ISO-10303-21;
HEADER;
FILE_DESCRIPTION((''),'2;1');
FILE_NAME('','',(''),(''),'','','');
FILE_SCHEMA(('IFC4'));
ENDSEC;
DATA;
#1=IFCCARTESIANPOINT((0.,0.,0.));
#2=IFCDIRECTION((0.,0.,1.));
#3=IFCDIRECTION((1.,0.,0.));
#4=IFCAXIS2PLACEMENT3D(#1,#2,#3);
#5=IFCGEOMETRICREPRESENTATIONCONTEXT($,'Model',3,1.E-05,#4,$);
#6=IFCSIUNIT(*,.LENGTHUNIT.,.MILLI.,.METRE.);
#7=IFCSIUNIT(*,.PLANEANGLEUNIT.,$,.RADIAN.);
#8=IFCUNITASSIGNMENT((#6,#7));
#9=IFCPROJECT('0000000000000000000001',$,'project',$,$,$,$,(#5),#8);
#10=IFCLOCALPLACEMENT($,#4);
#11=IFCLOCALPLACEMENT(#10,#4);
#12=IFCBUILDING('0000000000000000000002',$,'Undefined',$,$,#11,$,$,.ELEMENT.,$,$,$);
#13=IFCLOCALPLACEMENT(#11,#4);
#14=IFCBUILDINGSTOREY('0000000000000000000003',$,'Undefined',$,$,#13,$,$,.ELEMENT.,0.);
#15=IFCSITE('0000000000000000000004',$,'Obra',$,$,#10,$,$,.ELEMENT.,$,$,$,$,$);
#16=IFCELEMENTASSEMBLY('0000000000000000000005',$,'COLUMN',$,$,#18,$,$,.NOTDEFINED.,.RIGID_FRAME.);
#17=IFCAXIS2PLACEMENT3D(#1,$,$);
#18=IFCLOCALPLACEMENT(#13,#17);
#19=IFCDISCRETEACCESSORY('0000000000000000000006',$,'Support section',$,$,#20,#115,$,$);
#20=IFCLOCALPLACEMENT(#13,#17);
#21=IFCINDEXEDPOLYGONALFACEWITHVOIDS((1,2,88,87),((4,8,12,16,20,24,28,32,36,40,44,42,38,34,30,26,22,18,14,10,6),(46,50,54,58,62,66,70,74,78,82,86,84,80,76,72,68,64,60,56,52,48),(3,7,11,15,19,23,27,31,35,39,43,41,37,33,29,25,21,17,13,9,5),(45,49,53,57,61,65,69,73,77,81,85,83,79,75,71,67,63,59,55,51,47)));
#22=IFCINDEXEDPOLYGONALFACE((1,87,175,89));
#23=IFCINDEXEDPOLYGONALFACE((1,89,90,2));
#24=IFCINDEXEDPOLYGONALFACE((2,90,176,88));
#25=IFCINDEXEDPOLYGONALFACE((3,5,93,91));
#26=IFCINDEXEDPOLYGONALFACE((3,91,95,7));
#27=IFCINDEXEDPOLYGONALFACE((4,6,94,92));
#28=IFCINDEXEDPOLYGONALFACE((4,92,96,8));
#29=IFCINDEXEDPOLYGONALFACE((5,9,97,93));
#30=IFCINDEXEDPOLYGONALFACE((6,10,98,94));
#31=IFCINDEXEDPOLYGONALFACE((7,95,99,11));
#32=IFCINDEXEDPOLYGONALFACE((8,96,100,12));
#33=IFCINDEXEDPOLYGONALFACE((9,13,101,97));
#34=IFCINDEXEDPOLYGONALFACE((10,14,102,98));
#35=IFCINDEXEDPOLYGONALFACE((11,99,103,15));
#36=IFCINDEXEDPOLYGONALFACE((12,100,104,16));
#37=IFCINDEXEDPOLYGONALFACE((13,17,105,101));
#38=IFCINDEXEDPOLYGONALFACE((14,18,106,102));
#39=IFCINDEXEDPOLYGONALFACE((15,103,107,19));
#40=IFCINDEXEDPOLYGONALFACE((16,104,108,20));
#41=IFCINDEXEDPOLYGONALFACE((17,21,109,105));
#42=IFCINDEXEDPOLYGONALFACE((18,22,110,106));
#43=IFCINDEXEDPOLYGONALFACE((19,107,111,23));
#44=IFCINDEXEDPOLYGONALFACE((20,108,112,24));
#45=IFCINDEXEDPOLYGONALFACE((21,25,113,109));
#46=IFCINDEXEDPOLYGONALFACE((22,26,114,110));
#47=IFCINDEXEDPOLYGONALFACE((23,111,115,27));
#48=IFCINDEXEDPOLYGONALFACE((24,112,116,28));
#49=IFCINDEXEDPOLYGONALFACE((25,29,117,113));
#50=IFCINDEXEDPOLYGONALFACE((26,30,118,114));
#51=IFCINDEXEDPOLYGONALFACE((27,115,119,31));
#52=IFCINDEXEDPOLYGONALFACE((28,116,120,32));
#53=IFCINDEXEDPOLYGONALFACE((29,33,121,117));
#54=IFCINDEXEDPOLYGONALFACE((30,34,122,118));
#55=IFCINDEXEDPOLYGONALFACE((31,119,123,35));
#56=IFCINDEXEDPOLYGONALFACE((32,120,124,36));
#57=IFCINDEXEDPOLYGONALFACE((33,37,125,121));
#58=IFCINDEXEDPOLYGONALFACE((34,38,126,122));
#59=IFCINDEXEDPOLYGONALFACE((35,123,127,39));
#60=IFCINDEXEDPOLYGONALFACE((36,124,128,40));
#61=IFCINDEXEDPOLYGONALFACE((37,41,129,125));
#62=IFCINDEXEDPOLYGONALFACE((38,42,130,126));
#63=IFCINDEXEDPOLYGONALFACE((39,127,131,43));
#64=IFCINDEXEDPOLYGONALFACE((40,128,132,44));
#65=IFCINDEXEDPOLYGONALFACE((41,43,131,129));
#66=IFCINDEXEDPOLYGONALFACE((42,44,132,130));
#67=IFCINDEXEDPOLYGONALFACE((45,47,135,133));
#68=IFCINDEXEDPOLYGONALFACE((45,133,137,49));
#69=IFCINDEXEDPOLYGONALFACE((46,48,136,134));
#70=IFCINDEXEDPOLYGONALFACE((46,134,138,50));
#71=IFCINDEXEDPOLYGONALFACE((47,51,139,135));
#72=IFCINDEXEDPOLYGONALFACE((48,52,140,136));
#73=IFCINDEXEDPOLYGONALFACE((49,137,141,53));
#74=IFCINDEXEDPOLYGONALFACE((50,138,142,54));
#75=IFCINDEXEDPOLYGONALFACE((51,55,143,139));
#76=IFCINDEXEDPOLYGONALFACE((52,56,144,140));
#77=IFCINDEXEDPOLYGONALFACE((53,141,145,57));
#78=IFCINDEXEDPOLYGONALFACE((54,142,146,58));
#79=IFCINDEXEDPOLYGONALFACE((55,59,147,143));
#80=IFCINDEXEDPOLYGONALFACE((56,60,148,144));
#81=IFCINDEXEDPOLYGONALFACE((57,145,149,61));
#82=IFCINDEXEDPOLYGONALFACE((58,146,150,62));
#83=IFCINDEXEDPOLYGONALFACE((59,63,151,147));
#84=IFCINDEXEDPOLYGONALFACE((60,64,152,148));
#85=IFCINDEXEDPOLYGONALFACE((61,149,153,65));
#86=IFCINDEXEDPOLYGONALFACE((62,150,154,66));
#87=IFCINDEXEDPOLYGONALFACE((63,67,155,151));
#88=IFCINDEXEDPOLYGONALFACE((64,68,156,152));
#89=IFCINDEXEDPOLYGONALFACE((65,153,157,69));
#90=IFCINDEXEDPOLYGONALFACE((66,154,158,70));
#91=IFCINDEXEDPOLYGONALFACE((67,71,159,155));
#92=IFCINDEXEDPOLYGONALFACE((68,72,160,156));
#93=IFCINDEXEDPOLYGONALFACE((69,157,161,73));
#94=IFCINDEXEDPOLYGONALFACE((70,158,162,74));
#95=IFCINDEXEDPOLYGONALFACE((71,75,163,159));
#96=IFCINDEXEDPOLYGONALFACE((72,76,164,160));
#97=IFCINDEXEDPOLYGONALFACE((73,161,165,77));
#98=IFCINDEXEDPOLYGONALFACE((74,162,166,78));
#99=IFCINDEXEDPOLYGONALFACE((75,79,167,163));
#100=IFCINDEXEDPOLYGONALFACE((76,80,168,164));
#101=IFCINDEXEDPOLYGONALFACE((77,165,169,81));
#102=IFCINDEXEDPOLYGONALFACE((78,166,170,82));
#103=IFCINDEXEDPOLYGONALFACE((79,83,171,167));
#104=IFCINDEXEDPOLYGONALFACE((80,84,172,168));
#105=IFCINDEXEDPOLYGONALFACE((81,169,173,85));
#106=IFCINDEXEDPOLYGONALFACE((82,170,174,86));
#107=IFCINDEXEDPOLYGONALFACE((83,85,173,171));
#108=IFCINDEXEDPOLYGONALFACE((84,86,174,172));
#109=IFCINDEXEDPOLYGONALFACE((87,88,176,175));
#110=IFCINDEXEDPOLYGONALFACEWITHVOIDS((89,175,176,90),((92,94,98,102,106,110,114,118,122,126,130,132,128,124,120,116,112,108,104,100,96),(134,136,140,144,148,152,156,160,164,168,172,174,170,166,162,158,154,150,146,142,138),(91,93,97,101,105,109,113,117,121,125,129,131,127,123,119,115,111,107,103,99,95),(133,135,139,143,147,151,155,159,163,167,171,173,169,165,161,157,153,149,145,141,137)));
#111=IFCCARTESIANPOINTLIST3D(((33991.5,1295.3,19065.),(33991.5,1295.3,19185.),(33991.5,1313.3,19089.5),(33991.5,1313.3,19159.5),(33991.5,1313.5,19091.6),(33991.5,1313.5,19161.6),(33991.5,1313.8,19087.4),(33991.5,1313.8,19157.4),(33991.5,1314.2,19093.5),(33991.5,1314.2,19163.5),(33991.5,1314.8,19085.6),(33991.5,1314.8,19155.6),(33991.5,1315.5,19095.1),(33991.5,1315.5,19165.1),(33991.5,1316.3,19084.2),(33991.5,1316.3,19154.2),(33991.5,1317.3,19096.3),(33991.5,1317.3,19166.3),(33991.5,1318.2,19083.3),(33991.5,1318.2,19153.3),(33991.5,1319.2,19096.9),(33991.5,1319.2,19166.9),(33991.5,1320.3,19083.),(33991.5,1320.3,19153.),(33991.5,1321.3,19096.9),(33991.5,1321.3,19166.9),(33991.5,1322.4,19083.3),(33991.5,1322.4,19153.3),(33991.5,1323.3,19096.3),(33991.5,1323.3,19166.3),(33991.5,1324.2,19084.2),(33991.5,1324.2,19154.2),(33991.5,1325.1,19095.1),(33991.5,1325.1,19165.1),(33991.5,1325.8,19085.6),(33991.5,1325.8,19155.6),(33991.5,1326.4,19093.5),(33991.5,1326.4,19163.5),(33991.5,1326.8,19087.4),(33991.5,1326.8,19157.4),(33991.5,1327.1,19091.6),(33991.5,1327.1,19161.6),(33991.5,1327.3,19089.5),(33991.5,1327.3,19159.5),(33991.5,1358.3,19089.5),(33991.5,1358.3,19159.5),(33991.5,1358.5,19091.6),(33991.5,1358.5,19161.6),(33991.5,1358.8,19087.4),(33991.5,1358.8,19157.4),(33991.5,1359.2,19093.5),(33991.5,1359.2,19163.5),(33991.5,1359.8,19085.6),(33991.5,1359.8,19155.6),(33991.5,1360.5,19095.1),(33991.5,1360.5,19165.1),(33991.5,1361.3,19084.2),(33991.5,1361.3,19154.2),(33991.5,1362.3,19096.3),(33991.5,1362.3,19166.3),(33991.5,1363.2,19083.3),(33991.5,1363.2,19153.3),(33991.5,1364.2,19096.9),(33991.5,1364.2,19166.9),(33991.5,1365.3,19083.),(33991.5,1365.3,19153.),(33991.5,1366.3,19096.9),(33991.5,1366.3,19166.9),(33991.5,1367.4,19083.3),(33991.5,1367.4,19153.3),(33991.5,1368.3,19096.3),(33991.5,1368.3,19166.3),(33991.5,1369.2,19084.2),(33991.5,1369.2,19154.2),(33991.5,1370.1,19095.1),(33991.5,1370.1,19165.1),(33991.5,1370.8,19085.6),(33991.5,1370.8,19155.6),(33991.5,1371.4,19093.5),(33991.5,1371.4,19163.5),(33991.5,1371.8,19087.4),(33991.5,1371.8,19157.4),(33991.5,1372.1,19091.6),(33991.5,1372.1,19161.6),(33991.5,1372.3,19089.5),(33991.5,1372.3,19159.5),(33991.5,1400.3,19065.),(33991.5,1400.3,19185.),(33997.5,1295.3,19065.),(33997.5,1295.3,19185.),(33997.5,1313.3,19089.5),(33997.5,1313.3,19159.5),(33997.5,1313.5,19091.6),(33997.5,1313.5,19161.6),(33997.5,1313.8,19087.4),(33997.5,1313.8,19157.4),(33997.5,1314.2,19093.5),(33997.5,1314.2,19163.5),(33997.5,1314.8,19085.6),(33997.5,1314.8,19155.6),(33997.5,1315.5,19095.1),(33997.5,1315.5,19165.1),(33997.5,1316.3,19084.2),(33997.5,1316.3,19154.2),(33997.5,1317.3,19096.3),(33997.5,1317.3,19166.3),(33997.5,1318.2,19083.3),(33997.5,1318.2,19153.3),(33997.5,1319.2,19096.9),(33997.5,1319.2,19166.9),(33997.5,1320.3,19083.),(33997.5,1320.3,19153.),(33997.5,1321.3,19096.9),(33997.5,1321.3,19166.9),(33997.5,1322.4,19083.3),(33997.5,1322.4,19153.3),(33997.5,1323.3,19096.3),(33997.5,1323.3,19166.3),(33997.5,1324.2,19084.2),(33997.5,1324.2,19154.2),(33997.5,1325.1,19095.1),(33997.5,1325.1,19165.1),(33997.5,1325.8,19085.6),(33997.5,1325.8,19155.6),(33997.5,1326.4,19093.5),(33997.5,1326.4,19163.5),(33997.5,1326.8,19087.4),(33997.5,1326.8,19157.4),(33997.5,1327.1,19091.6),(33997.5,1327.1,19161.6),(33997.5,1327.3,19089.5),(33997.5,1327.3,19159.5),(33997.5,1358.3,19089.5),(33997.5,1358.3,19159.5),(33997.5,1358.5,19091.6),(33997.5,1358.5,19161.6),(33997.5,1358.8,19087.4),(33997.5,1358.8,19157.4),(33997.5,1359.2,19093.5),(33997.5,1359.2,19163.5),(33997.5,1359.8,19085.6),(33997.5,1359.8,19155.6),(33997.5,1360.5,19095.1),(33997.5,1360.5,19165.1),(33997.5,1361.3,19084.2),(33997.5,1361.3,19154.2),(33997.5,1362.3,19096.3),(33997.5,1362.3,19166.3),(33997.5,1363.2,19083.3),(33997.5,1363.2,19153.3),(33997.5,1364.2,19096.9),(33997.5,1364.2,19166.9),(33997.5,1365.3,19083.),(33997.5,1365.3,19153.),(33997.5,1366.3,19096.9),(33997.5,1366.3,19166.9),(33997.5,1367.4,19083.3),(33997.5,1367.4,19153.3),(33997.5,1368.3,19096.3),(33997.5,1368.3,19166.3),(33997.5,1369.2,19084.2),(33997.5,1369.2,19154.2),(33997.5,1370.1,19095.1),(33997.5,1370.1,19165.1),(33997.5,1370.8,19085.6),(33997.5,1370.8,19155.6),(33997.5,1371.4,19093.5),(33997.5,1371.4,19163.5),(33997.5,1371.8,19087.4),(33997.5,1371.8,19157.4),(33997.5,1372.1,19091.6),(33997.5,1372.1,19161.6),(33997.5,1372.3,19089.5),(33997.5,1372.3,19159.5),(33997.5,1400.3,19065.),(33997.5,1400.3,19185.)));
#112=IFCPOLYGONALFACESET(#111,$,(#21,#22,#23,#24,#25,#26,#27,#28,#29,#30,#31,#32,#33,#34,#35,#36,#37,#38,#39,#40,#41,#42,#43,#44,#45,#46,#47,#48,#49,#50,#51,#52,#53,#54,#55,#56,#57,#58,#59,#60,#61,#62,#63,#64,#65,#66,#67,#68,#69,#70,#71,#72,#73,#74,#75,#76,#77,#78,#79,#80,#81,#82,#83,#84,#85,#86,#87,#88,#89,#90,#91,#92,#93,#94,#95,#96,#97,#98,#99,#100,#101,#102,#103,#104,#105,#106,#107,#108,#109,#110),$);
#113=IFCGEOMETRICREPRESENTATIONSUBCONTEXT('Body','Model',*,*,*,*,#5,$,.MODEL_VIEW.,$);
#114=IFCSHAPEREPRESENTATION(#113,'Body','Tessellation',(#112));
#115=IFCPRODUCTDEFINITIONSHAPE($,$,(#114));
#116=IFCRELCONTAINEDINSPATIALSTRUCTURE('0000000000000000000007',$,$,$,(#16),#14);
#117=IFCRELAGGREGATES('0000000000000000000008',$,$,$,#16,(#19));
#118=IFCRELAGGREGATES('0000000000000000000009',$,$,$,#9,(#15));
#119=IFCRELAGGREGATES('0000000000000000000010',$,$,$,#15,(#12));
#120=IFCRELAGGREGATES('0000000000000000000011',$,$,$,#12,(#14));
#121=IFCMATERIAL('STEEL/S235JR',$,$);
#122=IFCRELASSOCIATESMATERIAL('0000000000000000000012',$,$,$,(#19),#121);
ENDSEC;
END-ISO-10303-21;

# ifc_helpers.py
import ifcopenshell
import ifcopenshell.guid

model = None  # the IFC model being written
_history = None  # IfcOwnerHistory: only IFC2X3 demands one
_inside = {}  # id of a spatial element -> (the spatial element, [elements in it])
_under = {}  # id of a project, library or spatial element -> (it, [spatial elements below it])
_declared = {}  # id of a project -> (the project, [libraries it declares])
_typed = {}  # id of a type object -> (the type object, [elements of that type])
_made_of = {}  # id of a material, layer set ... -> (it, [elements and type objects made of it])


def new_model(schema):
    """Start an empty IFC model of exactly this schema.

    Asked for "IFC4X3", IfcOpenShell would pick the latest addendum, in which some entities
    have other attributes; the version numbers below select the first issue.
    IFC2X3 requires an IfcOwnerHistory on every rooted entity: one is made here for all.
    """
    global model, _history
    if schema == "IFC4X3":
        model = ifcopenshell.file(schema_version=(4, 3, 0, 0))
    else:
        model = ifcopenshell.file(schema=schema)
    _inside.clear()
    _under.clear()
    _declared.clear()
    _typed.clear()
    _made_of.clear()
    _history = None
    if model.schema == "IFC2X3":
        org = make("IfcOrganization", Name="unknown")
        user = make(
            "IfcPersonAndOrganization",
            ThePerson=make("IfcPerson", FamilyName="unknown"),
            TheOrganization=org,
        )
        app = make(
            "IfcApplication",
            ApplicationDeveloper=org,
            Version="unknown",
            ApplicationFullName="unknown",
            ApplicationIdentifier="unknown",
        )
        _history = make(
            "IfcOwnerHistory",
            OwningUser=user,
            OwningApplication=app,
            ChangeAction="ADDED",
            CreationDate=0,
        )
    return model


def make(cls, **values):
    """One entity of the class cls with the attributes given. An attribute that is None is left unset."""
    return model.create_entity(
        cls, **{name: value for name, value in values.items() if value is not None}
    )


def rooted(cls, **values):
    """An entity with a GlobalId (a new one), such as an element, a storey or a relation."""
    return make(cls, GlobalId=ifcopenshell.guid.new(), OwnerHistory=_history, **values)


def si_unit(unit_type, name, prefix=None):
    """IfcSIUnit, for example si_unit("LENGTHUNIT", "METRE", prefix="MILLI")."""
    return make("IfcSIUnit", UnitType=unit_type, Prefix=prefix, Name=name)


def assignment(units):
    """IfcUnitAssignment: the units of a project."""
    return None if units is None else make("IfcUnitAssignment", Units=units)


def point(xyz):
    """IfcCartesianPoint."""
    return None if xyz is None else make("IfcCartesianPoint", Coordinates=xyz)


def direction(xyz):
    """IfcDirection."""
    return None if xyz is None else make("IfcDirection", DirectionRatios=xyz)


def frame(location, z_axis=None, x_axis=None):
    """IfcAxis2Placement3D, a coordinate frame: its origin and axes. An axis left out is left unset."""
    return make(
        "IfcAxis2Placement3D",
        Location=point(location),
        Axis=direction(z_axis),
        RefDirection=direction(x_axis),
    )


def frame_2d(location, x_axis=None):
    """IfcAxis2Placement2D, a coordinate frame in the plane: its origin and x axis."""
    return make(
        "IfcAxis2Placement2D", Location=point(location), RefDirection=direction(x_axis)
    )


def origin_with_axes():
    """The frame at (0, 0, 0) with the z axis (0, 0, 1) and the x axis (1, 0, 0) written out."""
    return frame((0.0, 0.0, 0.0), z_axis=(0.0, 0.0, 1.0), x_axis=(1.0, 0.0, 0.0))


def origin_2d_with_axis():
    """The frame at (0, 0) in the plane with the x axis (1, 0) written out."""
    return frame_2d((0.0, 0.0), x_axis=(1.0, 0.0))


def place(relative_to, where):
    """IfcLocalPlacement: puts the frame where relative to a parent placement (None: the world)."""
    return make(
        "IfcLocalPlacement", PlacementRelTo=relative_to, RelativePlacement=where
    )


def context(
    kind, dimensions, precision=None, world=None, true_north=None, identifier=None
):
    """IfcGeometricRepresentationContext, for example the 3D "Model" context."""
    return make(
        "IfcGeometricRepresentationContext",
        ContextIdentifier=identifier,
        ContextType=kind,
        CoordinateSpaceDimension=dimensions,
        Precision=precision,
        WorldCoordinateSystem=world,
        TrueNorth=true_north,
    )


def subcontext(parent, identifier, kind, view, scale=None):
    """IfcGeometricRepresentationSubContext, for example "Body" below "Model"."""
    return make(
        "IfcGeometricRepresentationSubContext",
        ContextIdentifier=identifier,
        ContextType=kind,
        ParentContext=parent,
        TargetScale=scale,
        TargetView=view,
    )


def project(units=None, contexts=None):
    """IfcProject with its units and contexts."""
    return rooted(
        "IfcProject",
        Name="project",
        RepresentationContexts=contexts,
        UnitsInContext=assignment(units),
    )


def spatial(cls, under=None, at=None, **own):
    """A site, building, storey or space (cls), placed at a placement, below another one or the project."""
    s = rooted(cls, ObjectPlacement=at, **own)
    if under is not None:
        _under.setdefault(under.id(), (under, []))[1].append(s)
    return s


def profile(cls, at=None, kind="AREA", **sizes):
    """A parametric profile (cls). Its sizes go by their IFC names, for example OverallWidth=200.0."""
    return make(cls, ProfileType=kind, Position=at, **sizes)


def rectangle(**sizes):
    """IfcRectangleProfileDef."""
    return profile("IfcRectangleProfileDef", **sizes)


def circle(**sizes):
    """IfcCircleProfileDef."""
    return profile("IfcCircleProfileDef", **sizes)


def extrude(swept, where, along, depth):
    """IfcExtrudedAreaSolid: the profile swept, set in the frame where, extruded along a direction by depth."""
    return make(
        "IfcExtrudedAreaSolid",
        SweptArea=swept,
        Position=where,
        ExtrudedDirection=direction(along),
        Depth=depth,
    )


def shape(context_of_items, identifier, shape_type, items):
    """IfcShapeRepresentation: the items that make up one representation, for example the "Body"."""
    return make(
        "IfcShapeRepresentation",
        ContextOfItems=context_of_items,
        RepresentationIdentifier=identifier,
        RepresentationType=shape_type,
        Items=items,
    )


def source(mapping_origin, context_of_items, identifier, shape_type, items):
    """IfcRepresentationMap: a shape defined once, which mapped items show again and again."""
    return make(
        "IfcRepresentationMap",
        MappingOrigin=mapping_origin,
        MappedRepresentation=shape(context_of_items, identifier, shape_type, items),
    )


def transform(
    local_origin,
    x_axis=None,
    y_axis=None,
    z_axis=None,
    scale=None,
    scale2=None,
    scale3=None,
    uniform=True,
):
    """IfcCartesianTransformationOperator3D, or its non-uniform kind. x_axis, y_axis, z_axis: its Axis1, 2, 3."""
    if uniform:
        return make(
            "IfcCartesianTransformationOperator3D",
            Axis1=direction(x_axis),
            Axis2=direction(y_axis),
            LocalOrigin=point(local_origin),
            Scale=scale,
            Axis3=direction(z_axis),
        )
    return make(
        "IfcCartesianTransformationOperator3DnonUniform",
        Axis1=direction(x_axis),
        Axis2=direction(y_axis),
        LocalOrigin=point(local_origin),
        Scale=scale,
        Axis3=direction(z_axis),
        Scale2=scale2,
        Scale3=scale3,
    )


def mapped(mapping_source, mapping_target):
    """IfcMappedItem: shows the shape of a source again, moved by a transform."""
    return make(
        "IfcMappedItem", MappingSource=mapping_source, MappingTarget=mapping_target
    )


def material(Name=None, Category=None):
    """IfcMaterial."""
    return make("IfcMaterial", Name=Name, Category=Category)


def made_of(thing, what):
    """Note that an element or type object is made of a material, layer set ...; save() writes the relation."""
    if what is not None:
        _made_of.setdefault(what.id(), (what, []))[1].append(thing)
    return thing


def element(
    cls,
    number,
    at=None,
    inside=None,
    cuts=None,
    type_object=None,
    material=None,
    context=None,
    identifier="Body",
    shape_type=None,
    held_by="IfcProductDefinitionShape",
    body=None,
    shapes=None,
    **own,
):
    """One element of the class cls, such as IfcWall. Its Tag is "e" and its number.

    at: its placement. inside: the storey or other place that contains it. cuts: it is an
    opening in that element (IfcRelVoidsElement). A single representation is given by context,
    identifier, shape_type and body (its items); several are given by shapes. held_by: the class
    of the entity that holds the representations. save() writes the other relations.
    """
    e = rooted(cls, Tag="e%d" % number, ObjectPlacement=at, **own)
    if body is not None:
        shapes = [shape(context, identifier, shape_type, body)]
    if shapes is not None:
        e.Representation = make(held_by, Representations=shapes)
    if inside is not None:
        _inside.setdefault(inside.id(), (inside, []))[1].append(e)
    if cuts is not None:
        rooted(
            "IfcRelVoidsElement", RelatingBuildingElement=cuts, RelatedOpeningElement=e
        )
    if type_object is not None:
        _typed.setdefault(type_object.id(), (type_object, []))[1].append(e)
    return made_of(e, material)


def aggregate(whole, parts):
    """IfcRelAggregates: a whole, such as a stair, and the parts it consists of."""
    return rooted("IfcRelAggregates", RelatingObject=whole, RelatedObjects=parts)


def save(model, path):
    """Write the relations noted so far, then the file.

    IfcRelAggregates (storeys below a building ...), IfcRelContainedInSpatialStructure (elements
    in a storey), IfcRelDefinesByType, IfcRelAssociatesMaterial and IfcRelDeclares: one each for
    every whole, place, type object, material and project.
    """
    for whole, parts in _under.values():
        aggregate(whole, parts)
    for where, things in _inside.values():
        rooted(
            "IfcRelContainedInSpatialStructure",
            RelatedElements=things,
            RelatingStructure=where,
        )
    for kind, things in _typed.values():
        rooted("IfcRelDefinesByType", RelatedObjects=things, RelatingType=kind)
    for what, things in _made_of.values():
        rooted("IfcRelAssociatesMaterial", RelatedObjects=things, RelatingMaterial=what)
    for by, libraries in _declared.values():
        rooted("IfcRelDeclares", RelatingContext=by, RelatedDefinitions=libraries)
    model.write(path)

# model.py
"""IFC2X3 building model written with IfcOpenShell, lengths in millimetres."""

from ifc_helpers import new_model, si_unit, frame, origin_with_axes, origin_2d_with_axis, place, context, subcontext, project, spatial, rectangle, circle, extrude, source, transform, mapped, material, element, aggregate, save


model = new_model("IFC2X3")

# Units and contexts
model_context = context("Model", 3, precision=1e-05, world=origin_with_axes())
body_context = subcontext(model_context, "Body", "Model", "MODEL_VIEW")
ifc_project = project(units=[si_unit("LENGTHUNIT", "METRE", prefix="MILLI"), si_unit("PLANEANGLEUNIT", "RADIAN")], contexts=[model_context])

# Site, building, storey
site_placement = place(None, origin_with_axes())
site = spatial("IfcSite", under=ifc_project, at=site_placement, Name="Obra", CompositionType="ELEMENT")
building_placement = place(site_placement, origin_with_axes())
building = spatial("IfcBuilding", under=site, at=building_placement, Name="Undefined", CompositionType="ELEMENT")
storey_placement = place(building_placement, origin_with_axes())
storey = spatial("IfcBuildingStorey", under=building, at=storey_placement, Name="Undefined", CompositionType="ELEMENT", Elevation=0.0)

# Element assembly
assembly_1_placement = place(storey_placement, origin_with_axes())
assembly_1 = element("IfcElementAssembly", 1, at=assembly_1_placement, inside=storey, Name="COLUMN", AssemblyPlace="NOTDEFINED", PredefinedType="RIGID_FRAME")
ifc_material_1 = material(Name="STEEL/S235JR")

# Discrete accessory, opening
shared_shape_1 = source(origin_with_axes(), body_context, "Body", "SweptSolid", [
    extrude(circle(Radius=7.0, at=origin_2d_with_axis()), frame((0.0, -8.6, 0.0), z_axis=(0.0, 1.0, 0.0), x_axis=(1.0, 0.0, 0.0)), (0.0, 0.0, 1.0), 6.2),
])
discrete_accessory_1_placement = place(assembly_1_placement, frame((33994.5, 1347.8, 19065.0), z_axis=(0.0, 0.0, 1.0), x_axis=(0.0, 1.0, 0.0)))
discrete_accessory_1 = element("IfcDiscreteAccessory", 2, at=discrete_accessory_1_placement, material=ifc_material_1, Name="Support section", context=body_context, shape_type="SweptSolid", body=[
    extrude(rectangle(XDim=6.0, YDim=105.0, at=origin_2d_with_axis()), frame((0.0, 0.0, 120.0), z_axis=(0.0, 0.0, -1.0), x_axis=(0.0, 1.0, 0.0)), (0.0, 0.0, 1.0), 120.0),
])
opening_1_placement = place(assembly_1_placement, frame((34000.0, 1390.3, 19205.0), z_axis=(0.0, -1.0, 0.0), x_axis=(0.0, 0.0, -1.0)))
element("IfcOpeningElement", 3, at=opening_1_placement, cuts=discrete_accessory_1, ObjectType="Opening", context=body_context, shape_type="MappedRepresentation", body=[
    mapped(shared_shape_1, transform((45.0, 0.0, 25.0))),
    mapped(shared_shape_1, transform((45.0, 0.0, 70.0))),
    mapped(shared_shape_1, transform((115.0, 0.0, 25.0))),
    mapped(shared_shape_1, transform((115.0, 0.0, 70.0))),
])

aggregate(assembly_1, [discrete_accessory_1])

save(model, "model.ifc")
